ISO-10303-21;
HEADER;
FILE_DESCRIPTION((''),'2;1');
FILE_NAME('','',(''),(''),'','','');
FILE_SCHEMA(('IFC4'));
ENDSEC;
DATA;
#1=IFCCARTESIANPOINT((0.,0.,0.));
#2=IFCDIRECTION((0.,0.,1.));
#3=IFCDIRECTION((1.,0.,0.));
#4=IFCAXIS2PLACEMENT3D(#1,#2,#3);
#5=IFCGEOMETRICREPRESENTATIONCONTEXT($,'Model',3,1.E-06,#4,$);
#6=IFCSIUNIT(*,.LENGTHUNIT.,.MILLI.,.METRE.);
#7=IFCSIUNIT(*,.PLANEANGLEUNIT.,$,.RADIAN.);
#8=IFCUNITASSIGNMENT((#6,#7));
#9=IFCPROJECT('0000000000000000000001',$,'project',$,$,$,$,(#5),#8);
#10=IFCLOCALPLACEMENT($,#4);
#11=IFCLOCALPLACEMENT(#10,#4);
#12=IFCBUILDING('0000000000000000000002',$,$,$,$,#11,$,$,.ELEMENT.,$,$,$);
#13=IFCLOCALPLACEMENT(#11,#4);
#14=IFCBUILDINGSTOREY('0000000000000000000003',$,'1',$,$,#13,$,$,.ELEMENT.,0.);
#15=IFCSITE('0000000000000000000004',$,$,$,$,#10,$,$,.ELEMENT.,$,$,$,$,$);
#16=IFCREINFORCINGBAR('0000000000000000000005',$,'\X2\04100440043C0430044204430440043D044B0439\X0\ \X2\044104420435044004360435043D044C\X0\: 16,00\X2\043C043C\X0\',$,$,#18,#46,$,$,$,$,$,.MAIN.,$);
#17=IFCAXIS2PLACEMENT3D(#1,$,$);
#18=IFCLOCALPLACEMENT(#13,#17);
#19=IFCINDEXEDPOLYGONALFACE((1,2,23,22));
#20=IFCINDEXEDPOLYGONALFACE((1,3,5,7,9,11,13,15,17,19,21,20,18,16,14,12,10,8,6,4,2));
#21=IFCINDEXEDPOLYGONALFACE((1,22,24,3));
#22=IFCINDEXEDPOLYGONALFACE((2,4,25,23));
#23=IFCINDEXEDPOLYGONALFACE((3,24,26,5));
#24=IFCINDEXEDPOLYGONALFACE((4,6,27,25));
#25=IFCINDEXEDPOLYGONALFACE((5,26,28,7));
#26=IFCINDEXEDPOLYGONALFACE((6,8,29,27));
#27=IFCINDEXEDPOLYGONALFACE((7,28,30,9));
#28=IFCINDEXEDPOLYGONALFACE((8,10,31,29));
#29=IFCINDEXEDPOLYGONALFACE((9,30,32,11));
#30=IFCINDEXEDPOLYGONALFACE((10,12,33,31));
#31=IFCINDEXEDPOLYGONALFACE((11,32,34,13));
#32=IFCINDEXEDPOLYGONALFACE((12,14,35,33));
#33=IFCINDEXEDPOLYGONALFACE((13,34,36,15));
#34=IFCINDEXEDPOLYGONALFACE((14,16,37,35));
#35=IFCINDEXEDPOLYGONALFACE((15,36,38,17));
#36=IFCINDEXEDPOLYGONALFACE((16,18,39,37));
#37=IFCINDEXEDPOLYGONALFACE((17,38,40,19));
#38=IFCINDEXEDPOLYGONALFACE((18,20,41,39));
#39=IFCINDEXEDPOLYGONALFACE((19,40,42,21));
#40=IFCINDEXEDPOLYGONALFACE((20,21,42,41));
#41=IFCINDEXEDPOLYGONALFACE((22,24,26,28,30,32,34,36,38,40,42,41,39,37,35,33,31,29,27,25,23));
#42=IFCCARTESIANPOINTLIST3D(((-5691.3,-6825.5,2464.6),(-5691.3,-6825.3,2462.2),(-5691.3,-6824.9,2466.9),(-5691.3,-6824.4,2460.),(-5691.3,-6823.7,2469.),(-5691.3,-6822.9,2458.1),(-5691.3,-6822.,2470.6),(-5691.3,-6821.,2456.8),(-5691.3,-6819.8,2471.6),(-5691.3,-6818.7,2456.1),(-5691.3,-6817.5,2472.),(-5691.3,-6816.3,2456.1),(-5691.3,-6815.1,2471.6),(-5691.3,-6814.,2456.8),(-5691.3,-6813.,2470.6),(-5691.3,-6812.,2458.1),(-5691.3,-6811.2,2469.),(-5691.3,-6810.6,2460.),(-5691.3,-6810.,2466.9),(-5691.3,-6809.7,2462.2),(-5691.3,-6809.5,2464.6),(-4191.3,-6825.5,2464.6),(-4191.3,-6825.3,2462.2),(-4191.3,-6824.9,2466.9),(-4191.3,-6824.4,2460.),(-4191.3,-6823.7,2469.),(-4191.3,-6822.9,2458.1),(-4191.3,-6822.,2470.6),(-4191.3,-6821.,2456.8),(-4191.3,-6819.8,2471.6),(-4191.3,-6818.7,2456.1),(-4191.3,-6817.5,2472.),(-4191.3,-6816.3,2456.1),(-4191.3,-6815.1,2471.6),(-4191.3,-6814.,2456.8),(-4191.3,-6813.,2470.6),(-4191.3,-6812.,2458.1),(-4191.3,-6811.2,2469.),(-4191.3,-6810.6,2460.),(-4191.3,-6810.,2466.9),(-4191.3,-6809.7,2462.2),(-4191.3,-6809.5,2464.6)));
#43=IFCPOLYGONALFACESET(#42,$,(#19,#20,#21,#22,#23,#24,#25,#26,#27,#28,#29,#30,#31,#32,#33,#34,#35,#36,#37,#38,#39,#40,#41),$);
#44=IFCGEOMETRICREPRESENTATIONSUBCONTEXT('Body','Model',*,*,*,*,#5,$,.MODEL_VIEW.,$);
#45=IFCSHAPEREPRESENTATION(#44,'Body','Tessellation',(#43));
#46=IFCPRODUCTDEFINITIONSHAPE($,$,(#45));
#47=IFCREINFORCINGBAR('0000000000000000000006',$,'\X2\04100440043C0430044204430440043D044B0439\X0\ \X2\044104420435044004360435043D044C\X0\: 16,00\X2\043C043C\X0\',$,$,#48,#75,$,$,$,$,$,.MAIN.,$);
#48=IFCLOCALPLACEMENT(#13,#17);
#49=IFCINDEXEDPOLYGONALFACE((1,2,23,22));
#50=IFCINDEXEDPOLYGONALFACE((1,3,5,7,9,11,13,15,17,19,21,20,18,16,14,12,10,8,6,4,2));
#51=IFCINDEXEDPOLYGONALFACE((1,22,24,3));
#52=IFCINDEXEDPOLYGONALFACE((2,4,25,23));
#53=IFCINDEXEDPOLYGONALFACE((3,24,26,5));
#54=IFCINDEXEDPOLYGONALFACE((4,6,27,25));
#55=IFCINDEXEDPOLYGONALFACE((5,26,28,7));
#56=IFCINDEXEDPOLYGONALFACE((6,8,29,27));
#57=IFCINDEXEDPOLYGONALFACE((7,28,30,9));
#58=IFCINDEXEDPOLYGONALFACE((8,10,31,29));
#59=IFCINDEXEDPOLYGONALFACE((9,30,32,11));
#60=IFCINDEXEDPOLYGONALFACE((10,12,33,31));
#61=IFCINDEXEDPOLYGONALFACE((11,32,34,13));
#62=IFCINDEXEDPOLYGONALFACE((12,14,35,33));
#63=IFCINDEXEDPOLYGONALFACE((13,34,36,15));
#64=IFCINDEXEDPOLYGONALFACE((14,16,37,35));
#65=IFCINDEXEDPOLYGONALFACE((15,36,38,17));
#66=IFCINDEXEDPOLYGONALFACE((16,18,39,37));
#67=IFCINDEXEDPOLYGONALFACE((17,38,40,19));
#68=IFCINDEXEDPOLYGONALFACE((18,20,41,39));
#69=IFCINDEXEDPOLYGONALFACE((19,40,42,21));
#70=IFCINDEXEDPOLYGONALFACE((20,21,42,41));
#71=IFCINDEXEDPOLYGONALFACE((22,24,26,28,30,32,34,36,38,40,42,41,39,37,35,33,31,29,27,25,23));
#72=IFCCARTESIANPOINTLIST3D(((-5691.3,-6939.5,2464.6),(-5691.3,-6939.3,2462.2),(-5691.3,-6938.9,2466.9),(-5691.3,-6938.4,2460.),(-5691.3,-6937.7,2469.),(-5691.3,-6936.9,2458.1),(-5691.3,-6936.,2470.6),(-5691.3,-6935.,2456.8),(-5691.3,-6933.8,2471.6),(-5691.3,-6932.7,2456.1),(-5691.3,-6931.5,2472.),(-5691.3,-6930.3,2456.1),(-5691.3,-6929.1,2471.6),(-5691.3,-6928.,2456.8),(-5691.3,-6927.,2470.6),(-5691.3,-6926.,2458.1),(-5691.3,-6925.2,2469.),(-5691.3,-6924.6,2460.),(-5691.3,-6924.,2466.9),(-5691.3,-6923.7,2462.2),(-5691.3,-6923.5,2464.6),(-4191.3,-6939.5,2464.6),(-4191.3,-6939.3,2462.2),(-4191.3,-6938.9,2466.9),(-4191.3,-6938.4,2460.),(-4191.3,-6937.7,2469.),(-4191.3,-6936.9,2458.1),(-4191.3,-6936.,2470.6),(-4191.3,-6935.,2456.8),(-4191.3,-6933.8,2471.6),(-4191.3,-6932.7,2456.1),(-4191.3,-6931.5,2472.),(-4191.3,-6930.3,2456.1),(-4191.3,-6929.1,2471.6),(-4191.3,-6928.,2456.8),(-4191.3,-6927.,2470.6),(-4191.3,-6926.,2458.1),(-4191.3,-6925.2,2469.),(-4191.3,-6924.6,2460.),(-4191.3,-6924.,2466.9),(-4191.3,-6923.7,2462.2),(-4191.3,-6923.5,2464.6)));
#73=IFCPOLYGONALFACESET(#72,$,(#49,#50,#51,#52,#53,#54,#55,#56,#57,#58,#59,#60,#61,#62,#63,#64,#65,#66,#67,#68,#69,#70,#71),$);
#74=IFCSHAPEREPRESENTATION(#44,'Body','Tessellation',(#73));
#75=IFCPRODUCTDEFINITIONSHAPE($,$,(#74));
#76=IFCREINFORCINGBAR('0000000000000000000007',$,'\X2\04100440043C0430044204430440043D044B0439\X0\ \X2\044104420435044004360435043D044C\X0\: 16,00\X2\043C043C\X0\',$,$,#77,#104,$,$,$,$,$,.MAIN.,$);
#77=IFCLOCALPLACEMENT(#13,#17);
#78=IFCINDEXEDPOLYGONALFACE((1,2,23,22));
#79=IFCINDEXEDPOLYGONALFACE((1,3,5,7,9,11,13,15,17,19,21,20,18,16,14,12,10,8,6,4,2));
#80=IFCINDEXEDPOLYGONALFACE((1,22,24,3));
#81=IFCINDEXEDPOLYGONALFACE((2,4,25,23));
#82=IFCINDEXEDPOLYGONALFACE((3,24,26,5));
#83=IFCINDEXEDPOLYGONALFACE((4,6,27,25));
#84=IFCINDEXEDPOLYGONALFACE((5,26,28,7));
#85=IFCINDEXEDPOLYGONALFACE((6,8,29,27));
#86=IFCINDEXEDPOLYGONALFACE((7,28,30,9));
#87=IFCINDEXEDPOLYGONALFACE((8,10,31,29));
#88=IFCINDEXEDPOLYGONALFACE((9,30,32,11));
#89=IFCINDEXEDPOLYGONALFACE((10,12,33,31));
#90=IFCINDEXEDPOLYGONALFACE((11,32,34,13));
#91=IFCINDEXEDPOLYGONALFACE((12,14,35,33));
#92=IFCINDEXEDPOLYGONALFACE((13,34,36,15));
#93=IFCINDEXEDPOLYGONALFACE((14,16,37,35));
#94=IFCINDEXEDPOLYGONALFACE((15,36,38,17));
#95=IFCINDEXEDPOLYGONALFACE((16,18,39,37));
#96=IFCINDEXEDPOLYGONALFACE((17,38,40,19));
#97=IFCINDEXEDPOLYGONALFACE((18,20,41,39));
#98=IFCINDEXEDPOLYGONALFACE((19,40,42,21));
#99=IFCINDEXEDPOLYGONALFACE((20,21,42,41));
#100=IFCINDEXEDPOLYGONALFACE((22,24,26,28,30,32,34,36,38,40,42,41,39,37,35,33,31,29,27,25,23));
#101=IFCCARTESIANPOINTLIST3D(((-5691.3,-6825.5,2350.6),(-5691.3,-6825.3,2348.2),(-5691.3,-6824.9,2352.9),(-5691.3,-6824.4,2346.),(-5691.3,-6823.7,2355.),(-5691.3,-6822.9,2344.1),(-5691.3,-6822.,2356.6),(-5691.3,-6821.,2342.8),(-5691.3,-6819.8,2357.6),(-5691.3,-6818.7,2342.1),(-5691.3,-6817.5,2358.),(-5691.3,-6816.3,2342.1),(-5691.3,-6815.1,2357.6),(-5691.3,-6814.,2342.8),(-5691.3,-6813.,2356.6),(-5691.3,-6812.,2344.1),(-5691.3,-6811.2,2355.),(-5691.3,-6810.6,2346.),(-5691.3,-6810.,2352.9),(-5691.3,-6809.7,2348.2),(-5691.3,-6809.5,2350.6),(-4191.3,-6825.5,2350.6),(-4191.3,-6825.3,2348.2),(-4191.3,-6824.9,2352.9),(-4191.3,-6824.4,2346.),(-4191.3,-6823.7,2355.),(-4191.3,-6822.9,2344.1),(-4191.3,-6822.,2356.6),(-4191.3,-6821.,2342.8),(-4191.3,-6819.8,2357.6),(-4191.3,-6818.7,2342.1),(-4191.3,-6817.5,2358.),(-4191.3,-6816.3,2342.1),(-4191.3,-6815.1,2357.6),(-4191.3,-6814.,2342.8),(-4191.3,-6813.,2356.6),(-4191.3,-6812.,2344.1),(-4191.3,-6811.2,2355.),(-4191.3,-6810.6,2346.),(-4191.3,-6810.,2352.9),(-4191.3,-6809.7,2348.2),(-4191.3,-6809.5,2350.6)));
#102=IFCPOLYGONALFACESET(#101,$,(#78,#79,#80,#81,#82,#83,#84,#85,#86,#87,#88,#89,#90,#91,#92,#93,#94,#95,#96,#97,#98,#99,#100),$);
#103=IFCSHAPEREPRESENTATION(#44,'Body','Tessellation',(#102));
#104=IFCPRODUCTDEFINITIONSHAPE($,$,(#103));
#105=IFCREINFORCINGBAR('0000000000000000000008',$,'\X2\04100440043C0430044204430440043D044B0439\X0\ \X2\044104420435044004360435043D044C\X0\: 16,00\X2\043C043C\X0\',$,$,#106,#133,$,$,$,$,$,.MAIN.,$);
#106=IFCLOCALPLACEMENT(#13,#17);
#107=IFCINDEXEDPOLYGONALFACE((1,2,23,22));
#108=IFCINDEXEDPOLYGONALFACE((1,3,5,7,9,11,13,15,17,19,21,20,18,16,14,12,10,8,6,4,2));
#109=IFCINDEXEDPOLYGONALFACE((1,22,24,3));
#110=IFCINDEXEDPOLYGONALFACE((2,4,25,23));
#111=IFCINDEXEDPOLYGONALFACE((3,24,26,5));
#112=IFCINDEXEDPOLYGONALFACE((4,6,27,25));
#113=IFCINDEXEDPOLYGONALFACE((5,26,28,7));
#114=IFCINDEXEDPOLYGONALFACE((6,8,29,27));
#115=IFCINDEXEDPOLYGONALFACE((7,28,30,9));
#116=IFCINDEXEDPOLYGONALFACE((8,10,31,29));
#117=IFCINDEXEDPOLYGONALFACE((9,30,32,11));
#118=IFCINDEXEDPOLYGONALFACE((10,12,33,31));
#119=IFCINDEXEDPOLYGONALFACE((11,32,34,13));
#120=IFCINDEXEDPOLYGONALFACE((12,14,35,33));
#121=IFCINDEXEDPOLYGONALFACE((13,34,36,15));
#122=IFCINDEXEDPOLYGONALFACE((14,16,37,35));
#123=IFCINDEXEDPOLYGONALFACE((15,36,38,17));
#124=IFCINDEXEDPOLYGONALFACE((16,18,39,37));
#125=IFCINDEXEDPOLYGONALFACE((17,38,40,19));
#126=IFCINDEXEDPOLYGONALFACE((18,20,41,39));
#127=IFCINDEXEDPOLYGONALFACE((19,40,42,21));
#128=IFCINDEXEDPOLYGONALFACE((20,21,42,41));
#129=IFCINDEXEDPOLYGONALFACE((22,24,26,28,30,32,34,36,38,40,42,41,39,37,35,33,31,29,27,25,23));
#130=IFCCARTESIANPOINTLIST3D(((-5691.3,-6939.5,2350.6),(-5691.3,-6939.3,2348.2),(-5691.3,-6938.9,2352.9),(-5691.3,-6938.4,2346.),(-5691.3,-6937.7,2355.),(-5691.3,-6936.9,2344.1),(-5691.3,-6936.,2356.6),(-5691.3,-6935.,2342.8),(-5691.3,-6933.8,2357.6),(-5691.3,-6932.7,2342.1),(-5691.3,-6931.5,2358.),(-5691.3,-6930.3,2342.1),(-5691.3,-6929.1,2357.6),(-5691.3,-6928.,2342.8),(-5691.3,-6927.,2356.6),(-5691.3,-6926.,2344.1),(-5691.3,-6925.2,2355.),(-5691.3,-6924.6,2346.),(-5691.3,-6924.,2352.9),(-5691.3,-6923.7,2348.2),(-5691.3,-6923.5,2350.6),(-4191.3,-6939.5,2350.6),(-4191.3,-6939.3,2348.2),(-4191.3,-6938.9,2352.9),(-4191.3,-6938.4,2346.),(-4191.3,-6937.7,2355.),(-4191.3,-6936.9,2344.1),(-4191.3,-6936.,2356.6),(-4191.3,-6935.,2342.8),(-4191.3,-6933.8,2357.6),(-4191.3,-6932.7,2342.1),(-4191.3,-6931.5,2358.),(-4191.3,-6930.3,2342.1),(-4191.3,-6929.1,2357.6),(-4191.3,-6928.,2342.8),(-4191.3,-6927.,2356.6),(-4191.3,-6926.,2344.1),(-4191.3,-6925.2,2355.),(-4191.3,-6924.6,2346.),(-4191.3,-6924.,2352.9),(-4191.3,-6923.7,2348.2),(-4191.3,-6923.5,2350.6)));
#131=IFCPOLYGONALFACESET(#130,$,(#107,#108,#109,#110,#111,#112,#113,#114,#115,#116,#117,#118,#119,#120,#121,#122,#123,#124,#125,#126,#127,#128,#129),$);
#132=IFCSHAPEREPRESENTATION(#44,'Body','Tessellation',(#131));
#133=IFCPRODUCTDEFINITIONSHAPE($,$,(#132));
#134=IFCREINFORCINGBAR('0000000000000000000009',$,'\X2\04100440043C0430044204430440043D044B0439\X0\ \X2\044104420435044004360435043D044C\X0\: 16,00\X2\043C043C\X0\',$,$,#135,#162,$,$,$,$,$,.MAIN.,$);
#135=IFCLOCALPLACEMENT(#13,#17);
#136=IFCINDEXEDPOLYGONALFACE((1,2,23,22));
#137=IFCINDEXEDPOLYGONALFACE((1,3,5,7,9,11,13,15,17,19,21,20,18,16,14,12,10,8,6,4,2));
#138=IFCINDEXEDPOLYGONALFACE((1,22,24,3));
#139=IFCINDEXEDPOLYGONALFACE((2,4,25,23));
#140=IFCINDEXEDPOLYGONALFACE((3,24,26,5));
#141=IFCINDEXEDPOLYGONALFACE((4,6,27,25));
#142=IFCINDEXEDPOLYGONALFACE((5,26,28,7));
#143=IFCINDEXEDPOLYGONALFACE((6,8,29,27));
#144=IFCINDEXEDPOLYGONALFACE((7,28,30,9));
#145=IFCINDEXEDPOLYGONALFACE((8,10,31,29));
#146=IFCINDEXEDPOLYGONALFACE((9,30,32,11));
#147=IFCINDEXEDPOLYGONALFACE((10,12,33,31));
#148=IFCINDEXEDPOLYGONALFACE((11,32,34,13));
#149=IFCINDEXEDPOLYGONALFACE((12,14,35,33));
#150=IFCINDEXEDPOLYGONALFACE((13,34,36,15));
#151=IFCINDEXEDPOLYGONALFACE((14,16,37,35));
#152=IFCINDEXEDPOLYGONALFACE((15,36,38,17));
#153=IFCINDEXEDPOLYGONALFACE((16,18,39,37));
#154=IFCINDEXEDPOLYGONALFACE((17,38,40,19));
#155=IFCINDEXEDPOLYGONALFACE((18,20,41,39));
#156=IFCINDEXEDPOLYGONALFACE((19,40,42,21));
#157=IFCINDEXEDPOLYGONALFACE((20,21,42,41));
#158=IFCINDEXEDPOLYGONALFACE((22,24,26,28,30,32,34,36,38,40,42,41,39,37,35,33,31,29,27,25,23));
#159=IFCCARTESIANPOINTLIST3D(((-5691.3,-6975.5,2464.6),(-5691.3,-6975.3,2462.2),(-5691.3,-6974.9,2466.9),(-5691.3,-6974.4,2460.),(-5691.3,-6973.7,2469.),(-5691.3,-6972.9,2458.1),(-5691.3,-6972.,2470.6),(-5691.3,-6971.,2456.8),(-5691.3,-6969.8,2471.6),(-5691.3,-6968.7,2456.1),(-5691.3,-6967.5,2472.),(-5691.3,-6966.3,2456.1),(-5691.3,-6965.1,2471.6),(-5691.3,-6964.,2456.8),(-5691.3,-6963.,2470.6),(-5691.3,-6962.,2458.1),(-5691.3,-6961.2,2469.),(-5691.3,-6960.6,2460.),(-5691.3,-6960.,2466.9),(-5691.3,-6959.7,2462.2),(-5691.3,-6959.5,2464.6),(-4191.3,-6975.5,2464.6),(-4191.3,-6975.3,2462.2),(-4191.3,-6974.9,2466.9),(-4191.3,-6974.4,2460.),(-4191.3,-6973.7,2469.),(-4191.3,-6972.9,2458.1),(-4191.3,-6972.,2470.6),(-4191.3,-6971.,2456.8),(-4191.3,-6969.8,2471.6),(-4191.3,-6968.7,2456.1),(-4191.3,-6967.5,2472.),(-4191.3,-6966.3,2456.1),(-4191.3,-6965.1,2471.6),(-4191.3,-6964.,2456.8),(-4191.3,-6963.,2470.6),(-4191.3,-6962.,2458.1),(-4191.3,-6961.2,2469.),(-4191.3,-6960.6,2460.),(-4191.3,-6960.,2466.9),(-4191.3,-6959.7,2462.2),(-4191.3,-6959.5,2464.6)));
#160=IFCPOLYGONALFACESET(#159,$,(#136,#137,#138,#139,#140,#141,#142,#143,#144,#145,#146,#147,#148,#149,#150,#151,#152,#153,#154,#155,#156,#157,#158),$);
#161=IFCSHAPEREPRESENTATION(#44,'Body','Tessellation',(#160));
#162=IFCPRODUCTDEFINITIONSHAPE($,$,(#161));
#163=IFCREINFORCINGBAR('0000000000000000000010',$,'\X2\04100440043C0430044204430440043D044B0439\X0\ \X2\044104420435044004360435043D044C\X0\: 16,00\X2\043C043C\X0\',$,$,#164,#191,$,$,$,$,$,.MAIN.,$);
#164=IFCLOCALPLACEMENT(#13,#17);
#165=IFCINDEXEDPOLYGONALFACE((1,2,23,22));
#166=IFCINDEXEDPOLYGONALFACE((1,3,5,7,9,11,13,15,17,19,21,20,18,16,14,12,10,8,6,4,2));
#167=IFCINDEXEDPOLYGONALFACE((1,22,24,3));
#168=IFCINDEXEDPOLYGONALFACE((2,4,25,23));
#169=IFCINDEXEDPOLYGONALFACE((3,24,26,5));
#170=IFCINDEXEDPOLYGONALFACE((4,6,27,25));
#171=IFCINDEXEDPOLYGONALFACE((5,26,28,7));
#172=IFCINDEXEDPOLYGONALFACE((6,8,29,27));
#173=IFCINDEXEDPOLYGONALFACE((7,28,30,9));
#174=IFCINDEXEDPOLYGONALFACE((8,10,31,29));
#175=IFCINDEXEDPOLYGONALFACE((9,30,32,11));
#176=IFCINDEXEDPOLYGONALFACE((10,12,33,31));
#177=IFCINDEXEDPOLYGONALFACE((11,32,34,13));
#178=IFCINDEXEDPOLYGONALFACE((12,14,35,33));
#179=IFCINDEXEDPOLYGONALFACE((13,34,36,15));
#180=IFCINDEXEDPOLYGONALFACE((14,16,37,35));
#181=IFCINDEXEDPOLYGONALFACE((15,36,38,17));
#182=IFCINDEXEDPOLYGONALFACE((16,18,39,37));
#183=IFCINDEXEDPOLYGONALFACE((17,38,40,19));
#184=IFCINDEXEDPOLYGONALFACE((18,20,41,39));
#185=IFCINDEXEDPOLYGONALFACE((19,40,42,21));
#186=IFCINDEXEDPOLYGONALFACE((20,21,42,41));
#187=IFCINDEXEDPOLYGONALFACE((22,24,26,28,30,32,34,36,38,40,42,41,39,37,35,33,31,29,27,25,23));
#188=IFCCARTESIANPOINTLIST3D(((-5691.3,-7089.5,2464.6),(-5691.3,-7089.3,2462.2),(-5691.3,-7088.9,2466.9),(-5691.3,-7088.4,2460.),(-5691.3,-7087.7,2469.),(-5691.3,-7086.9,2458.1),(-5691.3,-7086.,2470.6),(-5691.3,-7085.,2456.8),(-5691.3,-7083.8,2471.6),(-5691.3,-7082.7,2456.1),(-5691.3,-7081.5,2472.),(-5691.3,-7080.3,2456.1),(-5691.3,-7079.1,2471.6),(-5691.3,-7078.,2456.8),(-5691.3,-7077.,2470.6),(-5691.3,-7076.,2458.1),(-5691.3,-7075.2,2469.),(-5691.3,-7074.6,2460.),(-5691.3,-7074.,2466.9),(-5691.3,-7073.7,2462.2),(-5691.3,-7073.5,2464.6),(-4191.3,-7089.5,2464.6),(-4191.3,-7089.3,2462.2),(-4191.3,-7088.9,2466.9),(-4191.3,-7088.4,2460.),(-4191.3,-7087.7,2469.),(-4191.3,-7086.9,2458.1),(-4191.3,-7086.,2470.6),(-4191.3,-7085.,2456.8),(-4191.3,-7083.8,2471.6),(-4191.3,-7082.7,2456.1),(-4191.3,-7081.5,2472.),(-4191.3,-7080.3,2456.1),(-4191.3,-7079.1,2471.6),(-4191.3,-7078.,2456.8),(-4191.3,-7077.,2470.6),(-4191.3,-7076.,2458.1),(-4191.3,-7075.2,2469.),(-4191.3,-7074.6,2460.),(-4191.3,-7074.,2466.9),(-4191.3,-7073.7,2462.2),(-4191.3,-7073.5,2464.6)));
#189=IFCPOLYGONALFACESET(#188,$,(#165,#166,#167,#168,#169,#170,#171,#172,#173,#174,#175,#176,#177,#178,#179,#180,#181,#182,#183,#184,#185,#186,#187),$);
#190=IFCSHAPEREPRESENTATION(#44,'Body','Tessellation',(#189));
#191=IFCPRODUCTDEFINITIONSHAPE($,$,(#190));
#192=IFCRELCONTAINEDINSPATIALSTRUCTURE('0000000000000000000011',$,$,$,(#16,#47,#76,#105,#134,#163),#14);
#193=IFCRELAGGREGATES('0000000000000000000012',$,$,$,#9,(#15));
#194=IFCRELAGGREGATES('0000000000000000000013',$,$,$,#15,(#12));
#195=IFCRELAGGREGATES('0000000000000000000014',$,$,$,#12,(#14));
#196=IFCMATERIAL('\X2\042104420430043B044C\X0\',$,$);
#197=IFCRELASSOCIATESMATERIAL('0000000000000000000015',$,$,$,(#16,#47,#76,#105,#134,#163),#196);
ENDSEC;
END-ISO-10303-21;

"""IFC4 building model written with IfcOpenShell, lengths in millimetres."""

from ifc_helpers import new_model, entity, si_unit, origin_with_axes, place, context, subcontext, project, spatial, source, transform, mapped, material, element, save


model = new_model("IFC4")

# Units and contexts
model_context = context("Model", 3, precision=1e-06, world=origin_with_axes())
body_context = subcontext(model_context, "Body", "Model", "MODEL_VIEW")
ifc_project = project(units=[si_unit("LENGTHUNIT", "METRE", prefix="MILLI"), si_unit("PLANEANGLEUNIT", "RADIAN")], contexts=[model_context])

# Site, building, storey
site_placement = place(None, origin_with_axes())
site = spatial("IfcSite", under=ifc_project, at=site_placement, CompositionType="ELEMENT")
building_placement = place(site_placement, origin_with_axes())
building = spatial("IfcBuilding", under=site, at=building_placement, CompositionType="ELEMENT")
storey_placement = place(building_placement, origin_with_axes())
storey = spatial("IfcBuildingStorey", under=building, at=storey_placement, Name="1", CompositionType="ELEMENT", Elevation=0.0)

# Reinforcing bars
ifc_material = material(Name="Сталь")
shared_shape_1 = source(origin_with_axes(), body_context, "Body", "AdvancedSweptSolid", [
    entity("IfcSweptDiskSolid", entity("IfcIndexedPolyCurve", entity("IfcCartesianPointList3D", [[0.0, 0.0, 0.0], [1500.0, 0.0, 0.0]]), [entity("IfcLineIndex", [1, 2])]), 8.0),
])
reinforcing_bar_1_placement = place(storey_placement, origin_with_axes())
element("IfcReinforcingBar", 1, at=reinforcing_bar_1_placement, inside=storey, material=ifc_material, Name="Арматурный стержень: 16,00мм", PredefinedType="MAIN", context=body_context, shape_type="MappedRepresentation", body=[
    mapped(shared_shape_1, transform((-4191.3, -6817.5, 2464.0), x_axis=(-1.0, 0.0, 0.0), y_axis=(0.0, -1.0, 0.0), z_axis=(0.0, 0.0, 1.0), scale=1.0)),
])
reinforcing_bar_2_placement = place(storey_placement, origin_with_axes())
element("IfcReinforcingBar", 2, at=reinforcing_bar_2_placement, inside=storey, material=ifc_material, Name="Арматурный стержень: 16,00мм", PredefinedType="MAIN", context=body_context, shape_type="MappedRepresentation", body=[
    mapped(shared_shape_1, transform((-4191.3, -6931.5, 2464.0), x_axis=(-1.0, 0.0, 0.0), y_axis=(0.0, -1.0, 0.0), z_axis=(0.0, 0.0, 1.0), scale=1.0)),
])
reinforcing_bar_3_placement = place(storey_placement, origin_with_axes())
element("IfcReinforcingBar", 3, at=reinforcing_bar_3_placement, inside=storey, material=ifc_material, Name="Арматурный стержень: 16,00мм", PredefinedType="MAIN", context=body_context, shape_type="MappedRepresentation", body=[
    mapped(shared_shape_1, transform((-4191.3, -6817.5, 2350.0), x_axis=(-1.0, 0.0, 0.0), y_axis=(0.0, -1.0, 0.0), z_axis=(0.0, 0.0, 1.0), scale=1.0)),
])
reinforcing_bar_4_placement = place(storey_placement, origin_with_axes())
element("IfcReinforcingBar", 4, at=reinforcing_bar_4_placement, inside=storey, material=ifc_material, Name="Арматурный стержень: 16,00мм", PredefinedType="MAIN", context=body_context, shape_type="MappedRepresentation", body=[
    mapped(shared_shape_1, transform((-4191.3, -6931.5, 2350.0), x_axis=(-1.0, 0.0, 0.0), y_axis=(0.0, -1.0, 0.0), z_axis=(0.0, 0.0, 1.0), scale=1.0)),
])
reinforcing_bar_5_placement = place(storey_placement, origin_with_axes())
element("IfcReinforcingBar", 5, at=reinforcing_bar_5_placement, inside=storey, material=ifc_material, Name="Арматурный стержень: 16,00мм", PredefinedType="MAIN", context=body_context, shape_type="MappedRepresentation", body=[
    mapped(shared_shape_1, transform((-4191.3, -6967.5, 2464.0), x_axis=(-1.0, 0.0, 0.0), y_axis=(0.0, -1.0, 0.0), z_axis=(0.0, 0.0, 1.0), scale=1.0)),
])
reinforcing_bar_6_placement = place(storey_placement, origin_with_axes())
element("IfcReinforcingBar", 6, at=reinforcing_bar_6_placement, inside=storey, material=ifc_material, Name="Арматурный стержень: 16,00мм", PredefinedType="MAIN", context=body_context, shape_type="MappedRepresentation", body=[
    mapped(shared_shape_1, transform((-4191.3, -7081.5, 2464.0), x_axis=(-1.0, 0.0, 0.0), y_axis=(0.0, -1.0, 0.0), z_axis=(0.0, 0.0, 1.0), scale=1.0)),
])

save(model, "model.ifc")
